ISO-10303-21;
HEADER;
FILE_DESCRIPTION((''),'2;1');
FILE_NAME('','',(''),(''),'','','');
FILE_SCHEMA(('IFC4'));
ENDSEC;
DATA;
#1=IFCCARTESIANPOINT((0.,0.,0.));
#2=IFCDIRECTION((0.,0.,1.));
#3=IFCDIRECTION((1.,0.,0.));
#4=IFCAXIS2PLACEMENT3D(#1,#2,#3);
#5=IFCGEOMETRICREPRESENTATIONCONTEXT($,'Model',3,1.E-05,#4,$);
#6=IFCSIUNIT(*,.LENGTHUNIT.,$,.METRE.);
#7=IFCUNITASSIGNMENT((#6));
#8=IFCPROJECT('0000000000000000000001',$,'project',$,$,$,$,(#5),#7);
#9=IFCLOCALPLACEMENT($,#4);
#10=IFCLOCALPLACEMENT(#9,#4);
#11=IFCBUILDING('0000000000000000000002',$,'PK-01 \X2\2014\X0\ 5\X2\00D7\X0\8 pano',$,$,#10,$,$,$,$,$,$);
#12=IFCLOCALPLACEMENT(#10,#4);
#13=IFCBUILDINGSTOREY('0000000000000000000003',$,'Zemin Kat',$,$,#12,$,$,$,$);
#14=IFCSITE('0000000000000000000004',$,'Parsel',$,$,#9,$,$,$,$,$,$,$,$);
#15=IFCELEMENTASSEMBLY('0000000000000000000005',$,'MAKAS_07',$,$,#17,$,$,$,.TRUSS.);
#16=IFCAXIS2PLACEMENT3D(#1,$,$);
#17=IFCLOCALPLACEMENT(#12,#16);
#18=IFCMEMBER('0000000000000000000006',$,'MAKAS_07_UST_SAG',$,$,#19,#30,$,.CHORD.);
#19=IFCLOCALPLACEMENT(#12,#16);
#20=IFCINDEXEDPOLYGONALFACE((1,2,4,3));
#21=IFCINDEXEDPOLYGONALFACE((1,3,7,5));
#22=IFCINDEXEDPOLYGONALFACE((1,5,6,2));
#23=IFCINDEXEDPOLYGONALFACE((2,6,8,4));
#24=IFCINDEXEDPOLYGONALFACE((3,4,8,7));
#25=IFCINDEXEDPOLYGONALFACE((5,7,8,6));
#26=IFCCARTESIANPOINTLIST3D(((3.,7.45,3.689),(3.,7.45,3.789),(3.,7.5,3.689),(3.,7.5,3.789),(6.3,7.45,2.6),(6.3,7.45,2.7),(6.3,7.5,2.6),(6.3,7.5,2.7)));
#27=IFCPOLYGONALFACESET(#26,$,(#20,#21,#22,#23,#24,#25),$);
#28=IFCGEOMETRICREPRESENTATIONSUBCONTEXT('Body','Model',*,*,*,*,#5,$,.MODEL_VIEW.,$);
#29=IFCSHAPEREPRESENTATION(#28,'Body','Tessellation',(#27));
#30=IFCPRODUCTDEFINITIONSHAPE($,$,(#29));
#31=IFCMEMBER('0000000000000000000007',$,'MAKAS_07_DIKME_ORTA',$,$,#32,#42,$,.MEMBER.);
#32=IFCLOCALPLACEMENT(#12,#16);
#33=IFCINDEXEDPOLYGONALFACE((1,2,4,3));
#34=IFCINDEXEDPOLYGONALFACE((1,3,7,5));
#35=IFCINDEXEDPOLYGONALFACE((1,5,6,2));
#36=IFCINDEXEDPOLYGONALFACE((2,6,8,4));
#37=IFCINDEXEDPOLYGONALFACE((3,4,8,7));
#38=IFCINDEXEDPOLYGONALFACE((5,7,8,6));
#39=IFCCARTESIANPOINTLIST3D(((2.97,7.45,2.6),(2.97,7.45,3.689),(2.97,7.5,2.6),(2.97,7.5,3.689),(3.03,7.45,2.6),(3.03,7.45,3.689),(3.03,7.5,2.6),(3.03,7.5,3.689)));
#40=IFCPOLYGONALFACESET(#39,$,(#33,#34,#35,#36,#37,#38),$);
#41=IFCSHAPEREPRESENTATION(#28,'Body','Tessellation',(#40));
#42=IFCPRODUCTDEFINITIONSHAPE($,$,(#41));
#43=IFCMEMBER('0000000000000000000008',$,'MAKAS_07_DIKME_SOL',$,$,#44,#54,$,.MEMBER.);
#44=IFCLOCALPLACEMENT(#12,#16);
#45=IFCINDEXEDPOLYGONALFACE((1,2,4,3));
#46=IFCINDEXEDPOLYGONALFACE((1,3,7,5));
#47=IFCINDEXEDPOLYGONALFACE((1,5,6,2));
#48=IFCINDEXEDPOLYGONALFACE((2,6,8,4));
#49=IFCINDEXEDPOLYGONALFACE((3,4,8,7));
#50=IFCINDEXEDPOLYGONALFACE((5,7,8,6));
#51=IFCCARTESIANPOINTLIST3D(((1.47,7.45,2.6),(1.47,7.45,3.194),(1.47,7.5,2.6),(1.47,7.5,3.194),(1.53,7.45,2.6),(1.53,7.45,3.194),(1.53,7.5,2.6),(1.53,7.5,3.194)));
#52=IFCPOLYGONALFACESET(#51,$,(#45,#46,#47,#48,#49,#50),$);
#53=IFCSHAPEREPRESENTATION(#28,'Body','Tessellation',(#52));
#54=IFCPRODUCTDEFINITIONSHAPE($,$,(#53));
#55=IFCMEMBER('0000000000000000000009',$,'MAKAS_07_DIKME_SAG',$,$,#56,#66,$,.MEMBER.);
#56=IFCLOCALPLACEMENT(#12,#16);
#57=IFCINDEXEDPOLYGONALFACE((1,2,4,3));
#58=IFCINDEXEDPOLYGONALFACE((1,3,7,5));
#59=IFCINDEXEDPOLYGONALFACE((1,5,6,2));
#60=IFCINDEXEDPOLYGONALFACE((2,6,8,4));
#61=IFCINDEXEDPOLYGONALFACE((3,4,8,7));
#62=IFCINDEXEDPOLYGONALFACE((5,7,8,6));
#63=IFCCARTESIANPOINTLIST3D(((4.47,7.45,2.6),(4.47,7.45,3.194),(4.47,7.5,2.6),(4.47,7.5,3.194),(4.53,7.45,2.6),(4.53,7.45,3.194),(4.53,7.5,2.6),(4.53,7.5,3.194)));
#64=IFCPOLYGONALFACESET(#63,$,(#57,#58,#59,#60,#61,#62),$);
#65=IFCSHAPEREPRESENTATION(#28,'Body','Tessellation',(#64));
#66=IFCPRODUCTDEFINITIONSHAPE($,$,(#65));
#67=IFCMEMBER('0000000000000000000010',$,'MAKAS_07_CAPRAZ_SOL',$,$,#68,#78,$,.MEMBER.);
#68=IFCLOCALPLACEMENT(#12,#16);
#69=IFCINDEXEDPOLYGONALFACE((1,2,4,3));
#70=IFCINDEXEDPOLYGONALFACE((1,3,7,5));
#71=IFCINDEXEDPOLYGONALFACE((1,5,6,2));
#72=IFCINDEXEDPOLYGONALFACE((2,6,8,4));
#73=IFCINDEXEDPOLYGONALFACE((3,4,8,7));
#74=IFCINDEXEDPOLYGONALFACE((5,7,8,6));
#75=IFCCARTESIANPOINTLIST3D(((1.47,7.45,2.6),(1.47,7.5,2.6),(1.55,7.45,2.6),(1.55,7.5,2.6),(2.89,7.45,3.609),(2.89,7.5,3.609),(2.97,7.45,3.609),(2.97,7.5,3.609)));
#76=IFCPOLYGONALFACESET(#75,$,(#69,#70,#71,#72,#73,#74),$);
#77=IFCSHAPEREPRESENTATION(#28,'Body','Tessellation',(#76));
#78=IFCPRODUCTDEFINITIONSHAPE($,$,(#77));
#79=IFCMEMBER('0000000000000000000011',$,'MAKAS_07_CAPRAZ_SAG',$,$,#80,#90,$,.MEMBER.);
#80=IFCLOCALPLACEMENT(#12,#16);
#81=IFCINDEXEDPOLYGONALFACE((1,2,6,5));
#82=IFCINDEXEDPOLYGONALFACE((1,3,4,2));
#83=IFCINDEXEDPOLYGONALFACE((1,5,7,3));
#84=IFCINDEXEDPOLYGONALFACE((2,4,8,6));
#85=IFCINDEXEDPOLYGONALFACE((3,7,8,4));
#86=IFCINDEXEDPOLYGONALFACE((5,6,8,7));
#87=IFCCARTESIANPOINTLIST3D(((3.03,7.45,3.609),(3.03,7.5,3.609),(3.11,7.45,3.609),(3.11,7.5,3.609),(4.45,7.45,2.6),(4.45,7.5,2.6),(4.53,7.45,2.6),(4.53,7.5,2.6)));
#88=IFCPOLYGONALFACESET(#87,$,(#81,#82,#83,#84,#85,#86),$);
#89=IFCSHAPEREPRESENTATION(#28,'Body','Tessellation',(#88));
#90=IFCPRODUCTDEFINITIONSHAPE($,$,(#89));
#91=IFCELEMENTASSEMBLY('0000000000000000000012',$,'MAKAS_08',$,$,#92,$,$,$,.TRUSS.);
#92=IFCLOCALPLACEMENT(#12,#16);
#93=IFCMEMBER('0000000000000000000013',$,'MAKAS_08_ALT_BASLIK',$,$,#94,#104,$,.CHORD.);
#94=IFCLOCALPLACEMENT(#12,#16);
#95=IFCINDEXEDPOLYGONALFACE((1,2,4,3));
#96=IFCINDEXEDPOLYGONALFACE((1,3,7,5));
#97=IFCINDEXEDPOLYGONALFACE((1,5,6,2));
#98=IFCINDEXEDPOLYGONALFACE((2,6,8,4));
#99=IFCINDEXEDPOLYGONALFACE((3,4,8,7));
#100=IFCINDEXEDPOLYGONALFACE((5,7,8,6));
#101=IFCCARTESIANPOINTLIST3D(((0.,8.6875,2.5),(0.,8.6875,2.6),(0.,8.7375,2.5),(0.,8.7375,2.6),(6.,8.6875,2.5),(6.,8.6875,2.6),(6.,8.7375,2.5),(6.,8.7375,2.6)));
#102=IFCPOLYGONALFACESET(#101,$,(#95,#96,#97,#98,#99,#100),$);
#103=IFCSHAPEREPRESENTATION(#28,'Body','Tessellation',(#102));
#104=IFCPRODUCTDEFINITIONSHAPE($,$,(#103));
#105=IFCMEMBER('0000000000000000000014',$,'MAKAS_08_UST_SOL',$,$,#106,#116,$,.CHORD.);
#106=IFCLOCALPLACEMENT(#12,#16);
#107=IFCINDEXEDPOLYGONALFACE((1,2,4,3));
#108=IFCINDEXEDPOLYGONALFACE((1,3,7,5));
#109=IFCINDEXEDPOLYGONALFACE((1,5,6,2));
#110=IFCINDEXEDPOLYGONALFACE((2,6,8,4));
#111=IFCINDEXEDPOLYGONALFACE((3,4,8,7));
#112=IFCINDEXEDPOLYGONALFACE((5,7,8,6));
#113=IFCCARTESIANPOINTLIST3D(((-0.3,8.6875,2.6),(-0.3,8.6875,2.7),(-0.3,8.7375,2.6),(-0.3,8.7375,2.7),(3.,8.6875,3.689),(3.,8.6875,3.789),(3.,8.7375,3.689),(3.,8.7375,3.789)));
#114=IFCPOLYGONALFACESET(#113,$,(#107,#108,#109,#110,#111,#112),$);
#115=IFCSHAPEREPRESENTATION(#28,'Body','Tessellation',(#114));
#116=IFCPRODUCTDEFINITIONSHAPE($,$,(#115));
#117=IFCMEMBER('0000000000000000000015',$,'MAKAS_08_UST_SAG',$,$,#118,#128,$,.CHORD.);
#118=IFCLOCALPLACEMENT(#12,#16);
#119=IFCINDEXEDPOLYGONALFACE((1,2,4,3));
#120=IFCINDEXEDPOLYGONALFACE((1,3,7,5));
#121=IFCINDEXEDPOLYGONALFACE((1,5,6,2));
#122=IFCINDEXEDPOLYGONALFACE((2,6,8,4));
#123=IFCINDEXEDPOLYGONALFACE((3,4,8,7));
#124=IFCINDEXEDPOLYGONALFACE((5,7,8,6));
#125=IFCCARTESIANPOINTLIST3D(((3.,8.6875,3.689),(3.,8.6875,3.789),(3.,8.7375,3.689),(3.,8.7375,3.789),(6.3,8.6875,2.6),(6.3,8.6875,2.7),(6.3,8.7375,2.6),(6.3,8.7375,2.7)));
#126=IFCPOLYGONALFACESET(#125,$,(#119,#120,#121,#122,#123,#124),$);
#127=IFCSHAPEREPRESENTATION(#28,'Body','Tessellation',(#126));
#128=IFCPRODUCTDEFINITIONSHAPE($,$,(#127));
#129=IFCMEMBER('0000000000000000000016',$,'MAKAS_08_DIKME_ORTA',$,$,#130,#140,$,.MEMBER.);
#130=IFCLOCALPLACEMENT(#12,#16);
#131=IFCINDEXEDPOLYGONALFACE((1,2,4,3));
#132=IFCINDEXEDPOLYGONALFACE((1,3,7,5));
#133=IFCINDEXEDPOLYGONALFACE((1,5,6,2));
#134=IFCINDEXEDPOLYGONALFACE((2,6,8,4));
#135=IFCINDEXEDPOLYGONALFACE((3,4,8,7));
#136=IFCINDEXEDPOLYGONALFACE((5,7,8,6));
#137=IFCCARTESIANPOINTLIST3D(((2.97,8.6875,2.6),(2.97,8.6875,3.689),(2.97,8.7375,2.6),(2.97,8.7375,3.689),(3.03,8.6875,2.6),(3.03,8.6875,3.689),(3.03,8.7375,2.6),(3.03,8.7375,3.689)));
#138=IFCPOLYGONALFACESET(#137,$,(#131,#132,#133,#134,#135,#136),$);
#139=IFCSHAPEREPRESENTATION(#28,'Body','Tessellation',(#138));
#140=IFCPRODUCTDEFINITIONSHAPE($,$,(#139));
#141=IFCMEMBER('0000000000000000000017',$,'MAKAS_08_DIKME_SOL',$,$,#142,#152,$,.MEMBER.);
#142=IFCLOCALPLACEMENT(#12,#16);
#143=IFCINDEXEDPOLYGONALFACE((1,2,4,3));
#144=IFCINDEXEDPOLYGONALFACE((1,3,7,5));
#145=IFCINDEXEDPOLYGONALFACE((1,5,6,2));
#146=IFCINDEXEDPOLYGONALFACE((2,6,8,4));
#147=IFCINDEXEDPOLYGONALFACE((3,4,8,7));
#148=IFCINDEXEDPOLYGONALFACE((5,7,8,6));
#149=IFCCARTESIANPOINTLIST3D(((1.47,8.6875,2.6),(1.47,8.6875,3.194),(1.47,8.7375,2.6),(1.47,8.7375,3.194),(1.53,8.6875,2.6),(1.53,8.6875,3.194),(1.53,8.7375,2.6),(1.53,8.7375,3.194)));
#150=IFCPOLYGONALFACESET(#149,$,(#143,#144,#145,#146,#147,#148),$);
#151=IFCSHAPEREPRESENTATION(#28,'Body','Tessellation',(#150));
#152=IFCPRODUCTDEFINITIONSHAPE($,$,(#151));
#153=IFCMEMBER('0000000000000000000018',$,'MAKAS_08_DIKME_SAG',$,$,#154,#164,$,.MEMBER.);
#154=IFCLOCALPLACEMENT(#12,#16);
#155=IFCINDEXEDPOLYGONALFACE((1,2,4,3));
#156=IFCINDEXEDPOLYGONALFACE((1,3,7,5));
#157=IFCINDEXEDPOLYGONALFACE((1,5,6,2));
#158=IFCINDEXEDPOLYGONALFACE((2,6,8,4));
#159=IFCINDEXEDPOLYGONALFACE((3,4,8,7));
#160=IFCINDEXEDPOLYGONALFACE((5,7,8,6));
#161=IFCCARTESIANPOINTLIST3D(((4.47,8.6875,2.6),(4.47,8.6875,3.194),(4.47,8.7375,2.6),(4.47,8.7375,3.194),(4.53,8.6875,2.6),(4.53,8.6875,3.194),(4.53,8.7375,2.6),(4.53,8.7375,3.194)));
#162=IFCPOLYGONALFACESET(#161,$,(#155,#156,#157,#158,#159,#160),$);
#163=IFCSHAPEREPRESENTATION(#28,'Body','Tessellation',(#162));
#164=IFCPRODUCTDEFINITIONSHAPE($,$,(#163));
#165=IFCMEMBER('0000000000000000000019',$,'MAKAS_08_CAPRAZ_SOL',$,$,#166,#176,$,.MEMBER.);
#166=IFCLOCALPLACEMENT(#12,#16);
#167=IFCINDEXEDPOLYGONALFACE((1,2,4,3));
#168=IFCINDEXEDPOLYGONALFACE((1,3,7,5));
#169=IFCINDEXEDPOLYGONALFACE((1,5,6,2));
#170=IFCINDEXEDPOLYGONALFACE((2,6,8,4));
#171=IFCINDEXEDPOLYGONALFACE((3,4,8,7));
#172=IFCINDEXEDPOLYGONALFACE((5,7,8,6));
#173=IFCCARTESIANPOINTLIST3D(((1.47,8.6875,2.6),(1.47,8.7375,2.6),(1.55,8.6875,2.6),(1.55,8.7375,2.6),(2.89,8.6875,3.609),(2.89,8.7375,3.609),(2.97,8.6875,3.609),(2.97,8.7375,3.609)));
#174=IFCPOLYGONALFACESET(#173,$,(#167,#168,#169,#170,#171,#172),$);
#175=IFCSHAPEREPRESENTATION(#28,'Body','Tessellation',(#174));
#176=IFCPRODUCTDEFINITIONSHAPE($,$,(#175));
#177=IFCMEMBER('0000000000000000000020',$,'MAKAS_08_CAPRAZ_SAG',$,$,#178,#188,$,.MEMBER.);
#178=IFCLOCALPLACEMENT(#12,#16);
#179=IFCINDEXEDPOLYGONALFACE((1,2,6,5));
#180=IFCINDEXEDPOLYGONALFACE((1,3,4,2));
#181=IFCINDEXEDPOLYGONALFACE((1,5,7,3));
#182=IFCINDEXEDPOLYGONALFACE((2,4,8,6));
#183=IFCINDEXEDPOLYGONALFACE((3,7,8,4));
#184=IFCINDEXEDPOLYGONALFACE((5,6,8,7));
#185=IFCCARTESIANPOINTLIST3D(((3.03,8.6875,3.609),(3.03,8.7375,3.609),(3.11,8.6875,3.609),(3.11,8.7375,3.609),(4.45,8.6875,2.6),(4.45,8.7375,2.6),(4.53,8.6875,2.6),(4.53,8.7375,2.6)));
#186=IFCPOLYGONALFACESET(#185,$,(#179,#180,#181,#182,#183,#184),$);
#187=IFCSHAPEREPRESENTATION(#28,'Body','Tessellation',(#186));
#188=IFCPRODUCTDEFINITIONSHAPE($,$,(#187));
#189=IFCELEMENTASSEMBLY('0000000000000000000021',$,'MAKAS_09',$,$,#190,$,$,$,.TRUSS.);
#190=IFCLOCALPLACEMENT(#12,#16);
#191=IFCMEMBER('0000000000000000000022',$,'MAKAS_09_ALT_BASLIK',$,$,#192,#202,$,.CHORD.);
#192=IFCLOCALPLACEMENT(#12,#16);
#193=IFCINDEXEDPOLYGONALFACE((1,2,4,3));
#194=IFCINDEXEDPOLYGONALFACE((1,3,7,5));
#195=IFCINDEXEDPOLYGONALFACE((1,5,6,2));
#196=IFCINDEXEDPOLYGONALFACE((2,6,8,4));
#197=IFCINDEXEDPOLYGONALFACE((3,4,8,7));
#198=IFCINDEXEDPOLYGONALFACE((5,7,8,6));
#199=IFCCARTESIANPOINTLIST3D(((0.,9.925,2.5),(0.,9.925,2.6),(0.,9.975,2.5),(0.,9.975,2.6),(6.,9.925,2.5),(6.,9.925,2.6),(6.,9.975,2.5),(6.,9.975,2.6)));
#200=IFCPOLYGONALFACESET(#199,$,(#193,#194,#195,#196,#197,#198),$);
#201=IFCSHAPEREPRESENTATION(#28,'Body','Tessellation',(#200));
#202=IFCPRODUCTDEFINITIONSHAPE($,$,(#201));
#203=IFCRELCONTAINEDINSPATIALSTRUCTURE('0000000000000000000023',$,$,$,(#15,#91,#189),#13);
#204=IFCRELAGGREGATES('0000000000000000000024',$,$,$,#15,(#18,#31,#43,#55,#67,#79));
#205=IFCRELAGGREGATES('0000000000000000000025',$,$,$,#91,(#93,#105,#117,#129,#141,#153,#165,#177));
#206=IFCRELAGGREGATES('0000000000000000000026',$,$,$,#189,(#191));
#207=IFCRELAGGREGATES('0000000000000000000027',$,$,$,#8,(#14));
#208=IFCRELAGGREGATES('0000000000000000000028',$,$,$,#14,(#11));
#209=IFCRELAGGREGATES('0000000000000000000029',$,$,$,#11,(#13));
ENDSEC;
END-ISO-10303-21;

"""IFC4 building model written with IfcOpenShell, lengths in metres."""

from ifc_helpers import new_model, si_unit, frame, origin_with_axes, place, context, subcontext, project, spatial, line, indexed_curve, outline, extrude, element, aggregate, save


model = new_model("IFC4")

# Units and contexts
model_context = context("Model", 3, precision=1e-05, world=origin_with_axes())
body_context = subcontext(model_context, "Body", "Model", "MODEL_VIEW")
ifc_project = project(units=[si_unit("LENGTHUNIT", "METRE")], contexts=[model_context])

# Site, building, storey
site_placement = place(None, origin_with_axes())
site = spatial("IfcSite", under=ifc_project, at=site_placement, Name="Parsel")
building_placement = place(site_placement, origin_with_axes())
building = spatial("IfcBuilding", under=site, at=building_placement, Name="PK-01 — 5×8 pano")
storey_placement = place(building_placement, origin_with_axes())
storey = spatial("IfcBuildingStorey", under=building, at=storey_placement, Name="Zemin Kat")

# Element assemblies, members
assembly_1_placement = place(storey_placement, origin_with_axes())
assembly_1 = element("IfcElementAssembly", 1, at=assembly_1_placement, inside=storey, Name="MAKAS_07", PredefinedType="TRUSS")
member_1_placement = place(assembly_1_placement, origin_with_axes())
member_1 = element("IfcMember", 2, at=member_1_placement, Name="MAKAS_07_UST_SAG", PredefinedType="CHORD", context=body_context, shape_type="SweptSolid", body=[
    extrude(outline(indexed_curve([(3.0, 3.689), (6.3, 2.6), (6.3, 2.7), (3.0, 3.789)], segments=[line(1, 2, 3, 4, 1)])), frame((0.0, 7.5, 0.0), z_axis=(0.0, -1.0, 0.0), x_axis=(1.0, 0.0, 0.0)), (0.0, 0.0, 1.0), 0.05),
])
member_2_placement = place(assembly_1_placement, origin_with_axes())
member_2 = element("IfcMember", 3, at=member_2_placement, Name="MAKAS_07_DIKME_ORTA", PredefinedType="MEMBER", context=body_context, shape_type="SweptSolid", body=[
    extrude(outline(indexed_curve([(2.97, 2.6), (3.03, 2.6), (3.03, 3.689), (2.97, 3.689)], segments=[line(1, 2, 3, 4, 1)])), frame((0.0, 7.5, 0.0), z_axis=(0.0, -1.0, 0.0), x_axis=(1.0, 0.0, 0.0)), (0.0, 0.0, 1.0), 0.05),
])
member_3_placement = place(assembly_1_placement, origin_with_axes())
member_3 = element("IfcMember", 4, at=member_3_placement, Name="MAKAS_07_DIKME_SOL", PredefinedType="MEMBER", context=body_context, shape_type="SweptSolid", body=[
    extrude(outline(indexed_curve([(1.47, 2.6), (1.53, 2.6), (1.53, 3.194), (1.47, 3.194)], segments=[line(1, 2, 3, 4, 1)])), frame((0.0, 7.5, 0.0), z_axis=(0.0, -1.0, 0.0), x_axis=(1.0, 0.0, 0.0)), (0.0, 0.0, 1.0), 0.05),
])
member_4_placement = place(assembly_1_placement, origin_with_axes())
member_4 = element("IfcMember", 5, at=member_4_placement, Name="MAKAS_07_DIKME_SAG", PredefinedType="MEMBER", context=body_context, shape_type="SweptSolid", body=[
    extrude(outline(indexed_curve([(4.47, 2.6), (4.53, 2.6), (4.53, 3.194), (4.47, 3.194)], segments=[line(1, 2, 3, 4, 1)])), frame((0.0, 7.5, 0.0), z_axis=(0.0, -1.0, 0.0), x_axis=(1.0, 0.0, 0.0)), (0.0, 0.0, 1.0), 0.05),
])
member_5_placement = place(assembly_1_placement, origin_with_axes())
member_5 = element("IfcMember", 6, at=member_5_placement, Name="MAKAS_07_CAPRAZ_SOL", PredefinedType="MEMBER", context=body_context, shape_type="SweptSolid", body=[
    extrude(outline(indexed_curve([(1.47, 2.6), (1.55, 2.6), (2.97, 3.609), (2.89, 3.609)], segments=[line(1, 2, 3, 4, 1)])), frame((0.0, 7.5, 0.0), z_axis=(0.0, -1.0, 0.0), x_axis=(1.0, 0.0, 0.0)), (0.0, 0.0, 1.0), 0.05),
])
member_6_placement = place(assembly_1_placement, origin_with_axes())
member_6 = element("IfcMember", 7, at=member_6_placement, Name="MAKAS_07_CAPRAZ_SAG", PredefinedType="MEMBER", context=body_context, shape_type="SweptSolid", body=[
    extrude(outline(indexed_curve([(4.45, 2.6), (4.53, 2.6), (3.11, 3.609), (3.03, 3.609)], segments=[line(1, 2, 3, 4, 1)])), frame((0.0, 7.5, 0.0), z_axis=(0.0, -1.0, 0.0), x_axis=(1.0, 0.0, 0.0)), (0.0, 0.0, 1.0), 0.05),
])
aggregate(assembly_1, [member_1, member_2, member_3, member_4, member_5, member_6])
assembly_2_placement = place(storey_placement, origin_with_axes())
assembly_2 = element("IfcElementAssembly", 8, at=assembly_2_placement, inside=storey, Name="MAKAS_08", PredefinedType="TRUSS")
member_7_placement = place(assembly_2_placement, origin_with_axes())
member_7 = element("IfcMember", 9, at=member_7_placement, Name="MAKAS_08_ALT_BASLIK", PredefinedType="CHORD", context=body_context, shape_type="SweptSolid", body=[
    extrude(outline(indexed_curve([(0.0, 2.5), (6.0, 2.5), (6.0, 2.6), (0.0, 2.6)], segments=[line(1, 2, 3, 4, 1)])), frame((0.0, 8.7375, 0.0), z_axis=(0.0, -1.0, 0.0), x_axis=(1.0, 0.0, 0.0)), (0.0, 0.0, 1.0), 0.05),
])
member_8_placement = place(assembly_2_placement, origin_with_axes())
member_8 = element("IfcMember", 10, at=member_8_placement, Name="MAKAS_08_UST_SOL", PredefinedType="CHORD", context=body_context, shape_type="SweptSolid", body=[
    extrude(outline(indexed_curve([(-0.3, 2.6), (3.0, 3.689), (3.0, 3.789), (-0.3, 2.7)], segments=[line(1, 2, 3, 4, 1)])), frame((0.0, 8.7375, 0.0), z_axis=(0.0, -1.0, 0.0), x_axis=(1.0, 0.0, 0.0)), (0.0, 0.0, 1.0), 0.05),
])
member_9_placement = place(assembly_2_placement, origin_with_axes())
member_9 = element("IfcMember", 11, at=member_9_placement, Name="MAKAS_08_UST_SAG", PredefinedType="CHORD", context=body_context, shape_type="SweptSolid", body=[
    extrude(outline(indexed_curve([(3.0, 3.689), (6.3, 2.6), (6.3, 2.7), (3.0, 3.789)], segments=[line(1, 2, 3, 4, 1)])), frame((0.0, 8.7375, 0.0), z_axis=(0.0, -1.0, 0.0), x_axis=(1.0, 0.0, 0.0)), (0.0, 0.0, 1.0), 0.05),
])
member_10_placement = place(assembly_2_placement, origin_with_axes())
member_10 = element("IfcMember", 12, at=member_10_placement, Name="MAKAS_08_DIKME_ORTA", PredefinedType="MEMBER", context=body_context, shape_type="SweptSolid", body=[
    extrude(outline(indexed_curve([(2.97, 2.6), (3.03, 2.6), (3.03, 3.689), (2.97, 3.689)], segments=[line(1, 2, 3, 4, 1)])), frame((0.0, 8.7375, 0.0), z_axis=(0.0, -1.0, 0.0), x_axis=(1.0, 0.0, 0.0)), (0.0, 0.0, 1.0), 0.05),
])
member_11_placement = place(assembly_2_placement, origin_with_axes())
member_11 = element("IfcMember", 13, at=member_11_placement, Name="MAKAS_08_DIKME_SOL", PredefinedType="MEMBER", context=body_context, shape_type="SweptSolid", body=[
    extrude(outline(indexed_curve([(1.47, 2.6), (1.53, 2.6), (1.53, 3.194), (1.47, 3.194)], segments=[line(1, 2, 3, 4, 1)])), frame((0.0, 8.7375, 0.0), z_axis=(0.0, -1.0, 0.0), x_axis=(1.0, 0.0, 0.0)), (0.0, 0.0, 1.0), 0.05),
])
member_12_placement = place(assembly_2_placement, origin_with_axes())
member_12 = element("IfcMember", 14, at=member_12_placement, Name="MAKAS_08_DIKME_SAG", PredefinedType="MEMBER", context=body_context, shape_type="SweptSolid", body=[
    extrude(outline(indexed_curve([(4.47, 2.6), (4.53, 2.6), (4.53, 3.194), (4.47, 3.194)], segments=[line(1, 2, 3, 4, 1)])), frame((0.0, 8.7375, 0.0), z_axis=(0.0, -1.0, 0.0), x_axis=(1.0, 0.0, 0.0)), (0.0, 0.0, 1.0), 0.05),
])
member_13_placement = place(assembly_2_placement, origin_with_axes())
member_13 = element("IfcMember", 15, at=member_13_placement, Name="MAKAS_08_CAPRAZ_SOL", PredefinedType="MEMBER", context=body_context, shape_type="SweptSolid", body=[
    extrude(outline(indexed_curve([(1.47, 2.6), (1.55, 2.6), (2.97, 3.609), (2.89, 3.609)], segments=[line(1, 2, 3, 4, 1)])), frame((0.0, 8.7375, 0.0), z_axis=(0.0, -1.0, 0.0), x_axis=(1.0, 0.0, 0.0)), (0.0, 0.0, 1.0), 0.05),
])
member_14_placement = place(assembly_2_placement, origin_with_axes())
member_14 = element("IfcMember", 16, at=member_14_placement, Name="MAKAS_08_CAPRAZ_SAG", PredefinedType="MEMBER", context=body_context, shape_type="SweptSolid", body=[
    extrude(outline(indexed_curve([(4.45, 2.6), (4.53, 2.6), (3.11, 3.609), (3.03, 3.609)], segments=[line(1, 2, 3, 4, 1)])), frame((0.0, 8.7375, 0.0), z_axis=(0.0, -1.0, 0.0), x_axis=(1.0, 0.0, 0.0)), (0.0, 0.0, 1.0), 0.05),
])
aggregate(assembly_2, [member_7, member_8, member_9, member_10, member_11, member_12, member_13, member_14])
assembly_3_placement = place(storey_placement, origin_with_axes())
assembly_3 = element("IfcElementAssembly", 17, at=assembly_3_placement, inside=storey, Name="MAKAS_09", PredefinedType="TRUSS")
member_15_placement = place(assembly_3_placement, origin_with_axes())
member_15 = element("IfcMember", 18, at=member_15_placement, Name="MAKAS_09_ALT_BASLIK", PredefinedType="CHORD", context=body_context, shape_type="SweptSolid", body=[
    extrude(outline(indexed_curve([(0.0, 2.5), (6.0, 2.5), (6.0, 2.6), (0.0, 2.6)], segments=[line(1, 2, 3, 4, 1)])), frame((0.0, 9.975, 0.0), z_axis=(0.0, -1.0, 0.0), x_axis=(1.0, 0.0, 0.0)), (0.0, 0.0, 1.0), 0.05),
])
aggregate(assembly_3, [member_15])

save(model, "model.ifc")
